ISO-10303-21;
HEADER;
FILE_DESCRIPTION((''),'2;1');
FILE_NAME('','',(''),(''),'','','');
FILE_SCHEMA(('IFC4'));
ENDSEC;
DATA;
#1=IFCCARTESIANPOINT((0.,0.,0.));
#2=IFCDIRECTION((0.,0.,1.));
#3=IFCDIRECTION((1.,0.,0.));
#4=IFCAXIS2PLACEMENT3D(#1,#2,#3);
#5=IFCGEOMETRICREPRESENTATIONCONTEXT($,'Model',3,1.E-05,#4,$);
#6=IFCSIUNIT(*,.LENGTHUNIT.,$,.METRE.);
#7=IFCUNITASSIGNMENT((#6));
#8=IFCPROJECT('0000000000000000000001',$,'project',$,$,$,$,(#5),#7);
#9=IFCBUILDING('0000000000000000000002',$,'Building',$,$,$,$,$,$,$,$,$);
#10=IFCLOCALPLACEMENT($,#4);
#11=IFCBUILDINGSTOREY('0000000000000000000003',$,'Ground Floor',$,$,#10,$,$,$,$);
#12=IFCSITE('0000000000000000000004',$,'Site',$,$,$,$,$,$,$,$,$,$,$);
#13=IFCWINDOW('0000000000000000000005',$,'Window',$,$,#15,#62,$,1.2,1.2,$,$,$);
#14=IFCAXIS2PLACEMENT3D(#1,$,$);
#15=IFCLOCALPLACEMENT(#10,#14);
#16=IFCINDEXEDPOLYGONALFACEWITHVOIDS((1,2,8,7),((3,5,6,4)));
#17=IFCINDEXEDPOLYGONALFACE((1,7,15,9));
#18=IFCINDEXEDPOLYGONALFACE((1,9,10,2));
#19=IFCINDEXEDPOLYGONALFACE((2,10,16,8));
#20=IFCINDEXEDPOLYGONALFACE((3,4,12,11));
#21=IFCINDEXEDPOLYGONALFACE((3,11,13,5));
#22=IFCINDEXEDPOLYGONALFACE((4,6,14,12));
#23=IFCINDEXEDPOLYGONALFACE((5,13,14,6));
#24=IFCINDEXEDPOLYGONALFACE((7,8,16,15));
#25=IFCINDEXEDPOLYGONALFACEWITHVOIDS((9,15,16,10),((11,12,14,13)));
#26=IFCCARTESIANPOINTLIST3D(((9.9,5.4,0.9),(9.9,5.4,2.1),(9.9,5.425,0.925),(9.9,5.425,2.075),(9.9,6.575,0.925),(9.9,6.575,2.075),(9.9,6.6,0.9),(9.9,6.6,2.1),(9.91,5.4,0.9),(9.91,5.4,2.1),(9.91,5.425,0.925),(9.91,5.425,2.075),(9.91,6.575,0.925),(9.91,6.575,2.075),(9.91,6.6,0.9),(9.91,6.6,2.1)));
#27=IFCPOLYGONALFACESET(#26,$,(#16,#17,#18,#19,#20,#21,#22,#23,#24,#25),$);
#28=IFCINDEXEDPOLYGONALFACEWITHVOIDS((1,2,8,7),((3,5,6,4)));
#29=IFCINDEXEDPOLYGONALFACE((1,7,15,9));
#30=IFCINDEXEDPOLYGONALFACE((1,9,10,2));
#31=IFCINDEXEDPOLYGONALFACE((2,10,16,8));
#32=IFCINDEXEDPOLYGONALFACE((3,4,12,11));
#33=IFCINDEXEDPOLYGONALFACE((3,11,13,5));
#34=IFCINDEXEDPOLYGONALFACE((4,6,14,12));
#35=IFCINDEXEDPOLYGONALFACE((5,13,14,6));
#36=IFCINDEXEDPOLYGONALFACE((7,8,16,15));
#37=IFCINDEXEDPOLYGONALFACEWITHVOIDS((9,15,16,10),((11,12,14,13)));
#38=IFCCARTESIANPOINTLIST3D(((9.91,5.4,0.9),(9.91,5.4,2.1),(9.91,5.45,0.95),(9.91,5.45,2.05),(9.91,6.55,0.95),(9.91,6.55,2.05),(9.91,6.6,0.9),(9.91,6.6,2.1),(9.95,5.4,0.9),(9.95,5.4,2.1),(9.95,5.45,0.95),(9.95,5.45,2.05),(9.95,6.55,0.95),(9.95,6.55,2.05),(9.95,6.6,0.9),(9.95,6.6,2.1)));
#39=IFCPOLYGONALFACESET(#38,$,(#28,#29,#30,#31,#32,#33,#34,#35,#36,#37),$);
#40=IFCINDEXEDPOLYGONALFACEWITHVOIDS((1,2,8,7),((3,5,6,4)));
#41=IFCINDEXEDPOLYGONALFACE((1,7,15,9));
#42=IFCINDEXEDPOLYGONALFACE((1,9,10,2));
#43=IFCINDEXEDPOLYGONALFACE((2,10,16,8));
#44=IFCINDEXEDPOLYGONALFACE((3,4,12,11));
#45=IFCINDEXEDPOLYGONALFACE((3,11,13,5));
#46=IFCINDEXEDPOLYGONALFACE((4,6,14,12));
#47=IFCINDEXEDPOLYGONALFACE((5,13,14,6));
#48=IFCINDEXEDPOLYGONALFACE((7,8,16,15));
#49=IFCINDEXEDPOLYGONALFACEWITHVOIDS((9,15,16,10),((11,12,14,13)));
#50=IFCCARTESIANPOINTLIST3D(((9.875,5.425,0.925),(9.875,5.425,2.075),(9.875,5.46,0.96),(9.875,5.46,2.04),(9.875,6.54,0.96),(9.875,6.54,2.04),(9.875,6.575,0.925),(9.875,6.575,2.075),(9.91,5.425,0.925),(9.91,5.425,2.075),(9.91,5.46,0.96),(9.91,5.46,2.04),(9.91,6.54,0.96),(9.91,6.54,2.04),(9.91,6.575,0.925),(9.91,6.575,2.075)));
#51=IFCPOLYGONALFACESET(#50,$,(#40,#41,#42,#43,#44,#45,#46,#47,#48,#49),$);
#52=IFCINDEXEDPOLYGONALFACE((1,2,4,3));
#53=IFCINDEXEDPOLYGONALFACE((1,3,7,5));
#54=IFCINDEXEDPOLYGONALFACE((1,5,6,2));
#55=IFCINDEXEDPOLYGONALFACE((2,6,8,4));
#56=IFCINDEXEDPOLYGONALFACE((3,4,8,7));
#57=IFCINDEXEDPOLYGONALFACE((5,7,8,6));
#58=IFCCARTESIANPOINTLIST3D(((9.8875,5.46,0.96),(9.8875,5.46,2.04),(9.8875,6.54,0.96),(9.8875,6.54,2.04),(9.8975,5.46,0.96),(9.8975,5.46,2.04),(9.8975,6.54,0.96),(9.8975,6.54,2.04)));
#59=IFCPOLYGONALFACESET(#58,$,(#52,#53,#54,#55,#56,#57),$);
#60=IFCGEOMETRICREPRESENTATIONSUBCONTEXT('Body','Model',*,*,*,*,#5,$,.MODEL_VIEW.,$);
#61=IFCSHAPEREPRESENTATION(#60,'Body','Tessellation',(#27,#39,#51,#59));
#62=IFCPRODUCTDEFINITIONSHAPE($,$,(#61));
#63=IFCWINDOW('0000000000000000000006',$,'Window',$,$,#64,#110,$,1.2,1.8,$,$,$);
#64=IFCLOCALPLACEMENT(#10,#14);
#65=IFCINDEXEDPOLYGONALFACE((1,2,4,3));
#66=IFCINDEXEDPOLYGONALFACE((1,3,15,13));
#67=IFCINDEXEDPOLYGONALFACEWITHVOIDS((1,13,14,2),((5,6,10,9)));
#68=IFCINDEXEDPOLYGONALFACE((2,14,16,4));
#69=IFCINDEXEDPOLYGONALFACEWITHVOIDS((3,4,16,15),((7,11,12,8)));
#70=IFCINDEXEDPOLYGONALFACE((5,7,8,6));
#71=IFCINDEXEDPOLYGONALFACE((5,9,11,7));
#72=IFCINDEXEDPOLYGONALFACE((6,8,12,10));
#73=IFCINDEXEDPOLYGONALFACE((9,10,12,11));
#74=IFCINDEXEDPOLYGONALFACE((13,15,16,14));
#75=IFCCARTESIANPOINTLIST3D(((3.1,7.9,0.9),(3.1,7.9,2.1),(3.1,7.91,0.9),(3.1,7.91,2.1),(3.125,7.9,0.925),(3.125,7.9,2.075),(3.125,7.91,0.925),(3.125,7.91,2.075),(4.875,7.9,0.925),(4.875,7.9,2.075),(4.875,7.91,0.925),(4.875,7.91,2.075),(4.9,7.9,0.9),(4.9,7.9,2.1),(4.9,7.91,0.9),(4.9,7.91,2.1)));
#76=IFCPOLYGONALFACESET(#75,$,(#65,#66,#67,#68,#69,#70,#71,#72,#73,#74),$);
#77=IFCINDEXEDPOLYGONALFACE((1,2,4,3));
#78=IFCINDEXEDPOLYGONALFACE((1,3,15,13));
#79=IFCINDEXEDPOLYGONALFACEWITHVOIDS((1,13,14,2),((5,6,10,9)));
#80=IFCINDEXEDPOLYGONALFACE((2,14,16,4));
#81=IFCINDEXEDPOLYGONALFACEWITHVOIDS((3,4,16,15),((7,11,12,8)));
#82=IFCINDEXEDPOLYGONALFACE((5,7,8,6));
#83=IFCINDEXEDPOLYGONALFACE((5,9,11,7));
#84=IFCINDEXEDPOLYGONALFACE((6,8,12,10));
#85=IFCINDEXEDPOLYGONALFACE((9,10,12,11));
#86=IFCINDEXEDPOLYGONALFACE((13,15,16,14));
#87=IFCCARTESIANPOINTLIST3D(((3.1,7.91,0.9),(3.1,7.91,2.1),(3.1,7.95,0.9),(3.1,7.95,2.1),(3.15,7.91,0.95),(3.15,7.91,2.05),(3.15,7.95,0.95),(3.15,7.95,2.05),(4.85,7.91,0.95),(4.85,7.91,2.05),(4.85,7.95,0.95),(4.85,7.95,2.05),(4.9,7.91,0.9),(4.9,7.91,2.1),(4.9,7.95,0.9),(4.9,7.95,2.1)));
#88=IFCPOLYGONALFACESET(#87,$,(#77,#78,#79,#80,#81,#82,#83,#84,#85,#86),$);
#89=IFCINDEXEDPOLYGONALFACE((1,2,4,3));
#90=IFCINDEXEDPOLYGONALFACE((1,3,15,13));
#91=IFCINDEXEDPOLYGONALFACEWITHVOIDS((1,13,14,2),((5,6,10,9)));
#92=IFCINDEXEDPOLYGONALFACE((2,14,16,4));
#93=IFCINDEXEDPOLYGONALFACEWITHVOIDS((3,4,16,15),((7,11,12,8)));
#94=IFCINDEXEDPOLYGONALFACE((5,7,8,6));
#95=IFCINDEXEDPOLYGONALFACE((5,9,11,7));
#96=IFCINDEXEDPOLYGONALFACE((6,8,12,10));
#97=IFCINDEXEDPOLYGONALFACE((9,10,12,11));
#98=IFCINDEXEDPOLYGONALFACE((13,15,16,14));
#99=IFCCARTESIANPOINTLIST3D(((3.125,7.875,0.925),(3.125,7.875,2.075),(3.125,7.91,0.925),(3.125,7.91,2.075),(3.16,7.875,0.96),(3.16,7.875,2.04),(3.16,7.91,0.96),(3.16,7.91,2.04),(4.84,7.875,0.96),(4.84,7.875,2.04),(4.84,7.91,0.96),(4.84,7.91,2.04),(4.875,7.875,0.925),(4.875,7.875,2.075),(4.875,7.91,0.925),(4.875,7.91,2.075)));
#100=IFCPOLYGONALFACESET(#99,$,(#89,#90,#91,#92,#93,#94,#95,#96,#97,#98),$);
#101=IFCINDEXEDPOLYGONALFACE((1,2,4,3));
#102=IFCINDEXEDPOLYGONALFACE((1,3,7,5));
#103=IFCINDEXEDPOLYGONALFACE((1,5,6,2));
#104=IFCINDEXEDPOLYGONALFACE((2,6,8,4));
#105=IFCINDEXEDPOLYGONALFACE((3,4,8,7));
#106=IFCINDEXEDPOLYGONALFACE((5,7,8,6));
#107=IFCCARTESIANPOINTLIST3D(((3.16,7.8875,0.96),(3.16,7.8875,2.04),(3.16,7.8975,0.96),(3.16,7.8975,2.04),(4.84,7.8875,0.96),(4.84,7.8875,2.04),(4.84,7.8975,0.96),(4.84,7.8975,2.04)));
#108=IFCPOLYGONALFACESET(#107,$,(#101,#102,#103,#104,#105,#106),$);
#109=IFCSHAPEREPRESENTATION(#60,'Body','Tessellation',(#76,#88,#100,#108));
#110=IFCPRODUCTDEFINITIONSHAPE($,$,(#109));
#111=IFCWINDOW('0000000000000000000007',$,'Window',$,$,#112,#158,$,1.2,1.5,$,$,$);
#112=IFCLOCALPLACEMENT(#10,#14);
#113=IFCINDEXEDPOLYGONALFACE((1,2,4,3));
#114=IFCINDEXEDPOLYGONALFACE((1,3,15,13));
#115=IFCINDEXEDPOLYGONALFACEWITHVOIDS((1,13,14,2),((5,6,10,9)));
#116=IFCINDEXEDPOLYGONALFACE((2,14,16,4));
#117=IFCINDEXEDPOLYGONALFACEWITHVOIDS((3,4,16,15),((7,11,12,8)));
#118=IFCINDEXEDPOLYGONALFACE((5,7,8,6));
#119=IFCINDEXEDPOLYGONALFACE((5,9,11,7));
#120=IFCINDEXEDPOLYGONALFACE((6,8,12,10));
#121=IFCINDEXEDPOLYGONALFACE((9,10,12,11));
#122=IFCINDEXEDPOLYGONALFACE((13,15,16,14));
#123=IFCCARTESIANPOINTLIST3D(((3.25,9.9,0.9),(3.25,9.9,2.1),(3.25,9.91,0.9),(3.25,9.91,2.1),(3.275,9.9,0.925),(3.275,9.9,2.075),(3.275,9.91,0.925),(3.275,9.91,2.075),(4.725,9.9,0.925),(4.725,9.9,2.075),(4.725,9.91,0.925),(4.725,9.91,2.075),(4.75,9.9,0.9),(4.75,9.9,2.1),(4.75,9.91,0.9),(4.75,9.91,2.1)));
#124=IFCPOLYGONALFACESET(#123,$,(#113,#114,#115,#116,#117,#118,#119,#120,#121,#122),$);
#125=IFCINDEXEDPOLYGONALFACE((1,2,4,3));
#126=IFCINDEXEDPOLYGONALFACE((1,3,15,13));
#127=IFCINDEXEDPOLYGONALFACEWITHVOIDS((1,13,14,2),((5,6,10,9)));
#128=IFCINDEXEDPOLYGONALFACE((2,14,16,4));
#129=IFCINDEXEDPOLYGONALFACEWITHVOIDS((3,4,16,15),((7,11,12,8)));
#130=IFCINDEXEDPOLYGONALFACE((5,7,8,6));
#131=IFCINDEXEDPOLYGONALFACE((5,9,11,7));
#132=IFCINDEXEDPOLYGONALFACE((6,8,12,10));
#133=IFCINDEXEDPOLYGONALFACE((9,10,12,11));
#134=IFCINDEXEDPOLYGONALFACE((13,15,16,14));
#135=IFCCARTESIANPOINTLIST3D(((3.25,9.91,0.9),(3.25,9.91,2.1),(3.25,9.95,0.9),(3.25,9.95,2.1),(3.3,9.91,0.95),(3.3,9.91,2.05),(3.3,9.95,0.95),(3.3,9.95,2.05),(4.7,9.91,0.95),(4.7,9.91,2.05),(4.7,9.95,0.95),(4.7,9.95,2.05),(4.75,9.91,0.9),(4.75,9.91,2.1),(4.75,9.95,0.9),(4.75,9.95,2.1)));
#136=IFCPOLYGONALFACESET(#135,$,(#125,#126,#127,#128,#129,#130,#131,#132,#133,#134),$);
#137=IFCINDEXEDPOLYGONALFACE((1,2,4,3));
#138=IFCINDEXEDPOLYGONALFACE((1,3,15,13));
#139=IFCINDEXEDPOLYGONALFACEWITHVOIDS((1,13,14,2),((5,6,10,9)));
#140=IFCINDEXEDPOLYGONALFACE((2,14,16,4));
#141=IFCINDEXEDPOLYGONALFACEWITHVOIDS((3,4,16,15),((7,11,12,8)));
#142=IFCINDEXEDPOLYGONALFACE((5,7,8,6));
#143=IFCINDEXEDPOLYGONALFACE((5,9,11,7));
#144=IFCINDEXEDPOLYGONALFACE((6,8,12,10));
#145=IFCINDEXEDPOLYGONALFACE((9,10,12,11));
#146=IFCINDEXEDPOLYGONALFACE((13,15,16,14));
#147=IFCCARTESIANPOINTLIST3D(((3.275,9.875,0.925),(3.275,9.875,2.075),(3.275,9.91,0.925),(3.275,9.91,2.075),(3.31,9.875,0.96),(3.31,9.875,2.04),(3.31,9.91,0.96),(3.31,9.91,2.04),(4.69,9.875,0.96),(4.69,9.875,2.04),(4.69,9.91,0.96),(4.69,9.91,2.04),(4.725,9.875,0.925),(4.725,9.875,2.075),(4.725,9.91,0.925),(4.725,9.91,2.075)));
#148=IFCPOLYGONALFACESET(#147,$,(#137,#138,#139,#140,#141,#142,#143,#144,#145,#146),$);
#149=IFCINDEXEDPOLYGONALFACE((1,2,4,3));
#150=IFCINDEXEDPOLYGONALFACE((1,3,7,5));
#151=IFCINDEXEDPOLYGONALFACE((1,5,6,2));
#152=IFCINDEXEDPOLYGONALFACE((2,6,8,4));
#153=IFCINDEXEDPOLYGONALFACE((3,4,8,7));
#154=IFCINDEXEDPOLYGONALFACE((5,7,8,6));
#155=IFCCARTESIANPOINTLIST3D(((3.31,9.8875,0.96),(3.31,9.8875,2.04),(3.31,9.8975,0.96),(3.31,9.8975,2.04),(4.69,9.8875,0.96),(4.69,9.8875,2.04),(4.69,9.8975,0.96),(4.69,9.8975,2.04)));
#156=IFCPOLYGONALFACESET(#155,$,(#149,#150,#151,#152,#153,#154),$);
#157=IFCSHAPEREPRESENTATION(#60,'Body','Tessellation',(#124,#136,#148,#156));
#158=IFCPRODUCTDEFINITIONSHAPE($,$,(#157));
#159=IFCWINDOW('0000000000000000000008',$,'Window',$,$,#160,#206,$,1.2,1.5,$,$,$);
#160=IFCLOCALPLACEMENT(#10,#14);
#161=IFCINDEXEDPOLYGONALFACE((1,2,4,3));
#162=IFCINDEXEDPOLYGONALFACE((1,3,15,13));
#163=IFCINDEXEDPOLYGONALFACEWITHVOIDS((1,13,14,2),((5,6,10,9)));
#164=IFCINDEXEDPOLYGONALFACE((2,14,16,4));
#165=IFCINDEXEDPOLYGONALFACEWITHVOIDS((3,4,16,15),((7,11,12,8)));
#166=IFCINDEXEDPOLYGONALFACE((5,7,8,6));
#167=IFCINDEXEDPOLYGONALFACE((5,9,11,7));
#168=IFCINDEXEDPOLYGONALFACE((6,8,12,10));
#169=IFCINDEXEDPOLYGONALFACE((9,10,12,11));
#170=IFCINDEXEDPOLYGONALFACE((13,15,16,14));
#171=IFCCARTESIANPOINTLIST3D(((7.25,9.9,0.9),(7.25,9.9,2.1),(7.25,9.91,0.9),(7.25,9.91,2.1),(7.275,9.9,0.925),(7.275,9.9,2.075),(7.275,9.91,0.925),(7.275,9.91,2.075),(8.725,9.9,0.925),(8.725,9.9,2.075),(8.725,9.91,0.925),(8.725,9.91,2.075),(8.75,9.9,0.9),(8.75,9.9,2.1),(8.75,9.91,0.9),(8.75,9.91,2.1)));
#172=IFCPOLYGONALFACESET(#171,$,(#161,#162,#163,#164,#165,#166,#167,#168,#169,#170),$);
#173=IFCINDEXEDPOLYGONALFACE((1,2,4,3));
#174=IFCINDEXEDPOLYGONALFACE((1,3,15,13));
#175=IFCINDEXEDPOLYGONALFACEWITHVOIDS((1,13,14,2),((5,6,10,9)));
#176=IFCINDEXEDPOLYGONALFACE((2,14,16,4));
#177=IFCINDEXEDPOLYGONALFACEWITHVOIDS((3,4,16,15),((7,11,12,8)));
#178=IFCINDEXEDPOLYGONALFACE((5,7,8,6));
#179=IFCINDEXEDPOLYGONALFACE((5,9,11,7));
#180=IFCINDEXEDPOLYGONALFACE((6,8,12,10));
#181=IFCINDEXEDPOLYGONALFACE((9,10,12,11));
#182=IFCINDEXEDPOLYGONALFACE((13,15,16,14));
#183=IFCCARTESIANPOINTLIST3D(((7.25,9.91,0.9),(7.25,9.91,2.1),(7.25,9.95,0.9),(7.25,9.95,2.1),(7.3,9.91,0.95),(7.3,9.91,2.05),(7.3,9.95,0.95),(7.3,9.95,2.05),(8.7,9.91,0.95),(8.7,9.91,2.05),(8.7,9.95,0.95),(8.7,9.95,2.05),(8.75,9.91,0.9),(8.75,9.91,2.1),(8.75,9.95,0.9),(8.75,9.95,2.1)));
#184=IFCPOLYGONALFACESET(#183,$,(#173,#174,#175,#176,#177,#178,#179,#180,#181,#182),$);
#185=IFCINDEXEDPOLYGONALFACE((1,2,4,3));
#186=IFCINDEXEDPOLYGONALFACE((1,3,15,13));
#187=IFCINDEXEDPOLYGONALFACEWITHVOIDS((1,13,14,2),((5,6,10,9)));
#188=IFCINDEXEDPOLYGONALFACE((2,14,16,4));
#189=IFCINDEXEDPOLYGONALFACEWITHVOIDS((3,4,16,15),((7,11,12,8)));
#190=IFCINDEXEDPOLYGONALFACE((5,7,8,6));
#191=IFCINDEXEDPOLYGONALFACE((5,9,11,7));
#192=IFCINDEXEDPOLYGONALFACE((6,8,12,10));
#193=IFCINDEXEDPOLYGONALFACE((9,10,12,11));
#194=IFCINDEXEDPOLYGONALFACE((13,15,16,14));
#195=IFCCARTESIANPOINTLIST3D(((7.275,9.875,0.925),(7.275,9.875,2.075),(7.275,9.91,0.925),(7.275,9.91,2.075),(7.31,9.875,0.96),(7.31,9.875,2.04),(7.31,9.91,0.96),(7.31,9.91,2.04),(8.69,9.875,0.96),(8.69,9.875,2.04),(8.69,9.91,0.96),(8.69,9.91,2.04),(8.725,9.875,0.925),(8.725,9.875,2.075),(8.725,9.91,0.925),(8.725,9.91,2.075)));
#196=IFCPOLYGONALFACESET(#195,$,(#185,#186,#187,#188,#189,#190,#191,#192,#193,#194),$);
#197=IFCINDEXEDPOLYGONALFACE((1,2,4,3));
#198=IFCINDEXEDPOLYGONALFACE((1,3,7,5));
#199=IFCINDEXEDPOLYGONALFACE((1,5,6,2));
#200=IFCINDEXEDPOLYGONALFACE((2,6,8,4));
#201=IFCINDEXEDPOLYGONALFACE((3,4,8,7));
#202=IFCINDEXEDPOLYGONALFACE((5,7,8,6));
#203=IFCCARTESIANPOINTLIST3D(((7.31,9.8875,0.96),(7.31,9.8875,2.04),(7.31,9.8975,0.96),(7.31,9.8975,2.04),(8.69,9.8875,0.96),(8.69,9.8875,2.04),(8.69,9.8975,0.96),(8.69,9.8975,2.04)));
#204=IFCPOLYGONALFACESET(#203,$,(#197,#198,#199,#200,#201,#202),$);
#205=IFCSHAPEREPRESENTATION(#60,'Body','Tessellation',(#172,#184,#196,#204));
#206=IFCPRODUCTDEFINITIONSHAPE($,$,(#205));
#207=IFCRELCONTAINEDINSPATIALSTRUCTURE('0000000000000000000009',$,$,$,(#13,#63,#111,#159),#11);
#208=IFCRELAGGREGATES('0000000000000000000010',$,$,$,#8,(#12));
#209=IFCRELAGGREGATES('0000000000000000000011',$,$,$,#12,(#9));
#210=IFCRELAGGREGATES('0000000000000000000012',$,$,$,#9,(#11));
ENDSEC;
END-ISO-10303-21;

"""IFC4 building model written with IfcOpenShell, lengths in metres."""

from ifc_helpers import new_model, si_unit, frame, origin_with_axes, place, context, subcontext, project, spatial, line, indexed_curve, outline, extrude, element, save


model = new_model("IFC4")

# Units and contexts
model_context = context("Model", 3, precision=1e-05, world=origin_with_axes())
body_context = subcontext(model_context, "Body", "Model", "MODEL_VIEW")
ifc_project = project(units=[si_unit("LENGTHUNIT", "METRE")], contexts=[model_context])

# Site, building, storey
site = spatial("IfcSite", under=ifc_project, Name="Site")
building = spatial("IfcBuilding", under=site, Name="Building")
storey_placement = place(None, origin_with_axes())
storey = spatial("IfcBuildingStorey", under=building, at=storey_placement, Name="Ground Floor")

# Windows
window_1_placement = place(storey_placement, frame((10.0, 5.4, 0.9), z_axis=(0.0, 0.0, 1.0), x_axis=(0.0, 1.0, 0.0)))
element("IfcWindow", 1, at=window_1_placement, inside=storey, Name="Window", OverallHeight=1.2, OverallWidth=1.2, context=body_context, shape_type="SweptSolid", body=[
    extrude(outline(indexed_curve([(0.0, 0.0), (1.2, 0.0), (1.2, 1.2), (0.0, 1.2)], segments=[line(1, 2, 3, 4, 1)]), holes=[indexed_curve([(0.025, 0.025), (1.175, 0.025), (1.175, 1.175), (0.025, 1.175)], segments=[line(1, 2, 3, 4, 1)])]), frame((0.0, 0.09, 0.0), z_axis=(0.0, -1.0, 0.0), x_axis=(1.0, 0.0, 0.0)), (0.0, 0.0, -1.0), 0.01),
    extrude(outline(indexed_curve([(0.0, 0.0), (1.2, 0.0), (1.2, 1.2), (0.0, 1.2)], segments=[line(1, 2, 3, 4, 1)]), holes=[indexed_curve([(0.05, 0.05), (1.15, 0.05), (1.15, 1.15), (0.05, 1.15)], segments=[line(1, 2, 3, 4, 1)])]), frame((0.0, 0.05, 0.0), z_axis=(0.0, -1.0, 0.0), x_axis=(1.0, 0.0, 0.0)), (0.0, 0.0, -1.0), 0.04),
    extrude(outline(indexed_curve([(0.0, 0.0), (1.15, 0.0), (1.15, 1.15), (0.0, 1.15)], segments=[line(1, 2, 3, 4, 1)]), holes=[indexed_curve([(0.035, 0.035), (1.115, 0.035), (1.115, 1.115), (0.035, 1.115)], segments=[line(1, 2, 3, 4, 1)])]), frame((0.025, 0.09, 0.025), z_axis=(0.0, -1.0, 0.0), x_axis=(1.0, 0.0, 0.0)), (0.0, 0.0, -1.0), 0.035),
    extrude(outline(indexed_curve([(0.035, 0.035), (1.115, 0.035), (1.115, 1.115), (0.035, 1.115)], segments=[line(1, 2, 3, 4, 1)])), frame((0.025, 0.1025, 0.025), z_axis=(0.0, -1.0, 0.0), x_axis=(1.0, 0.0, 0.0)), (0.0, 0.0, -1.0), 0.01),
])
window_2_placement = place(storey_placement, frame((4.9, 8.0, 0.9), z_axis=(0.0, 0.0, 1.0), x_axis=(-1.0, 0.0, 0.0)))
element("IfcWindow", 2, at=window_2_placement, inside=storey, Name="Window", OverallHeight=1.2, OverallWidth=1.8, context=body_context, shape_type="SweptSolid", body=[
    extrude(outline(indexed_curve([(0.0, 0.0), (1.8, 0.0), (1.8, 1.2), (0.0, 1.2)], segments=[line(1, 2, 3, 4, 1)]), holes=[indexed_curve([(0.025, 0.025), (1.775, 0.025), (1.775, 1.175), (0.025, 1.175)], segments=[line(1, 2, 3, 4, 1)])]), frame((0.0, 0.09, 0.0), z_axis=(0.0, -1.0, 0.0), x_axis=(1.0, 0.0, 0.0)), (0.0, 0.0, -1.0), 0.01),
    extrude(outline(indexed_curve([(0.0, 0.0), (1.8, 0.0), (1.8, 1.2), (0.0, 1.2)], segments=[line(1, 2, 3, 4, 1)]), holes=[indexed_curve([(0.05, 0.05), (1.75, 0.05), (1.75, 1.15), (0.05, 1.15)], segments=[line(1, 2, 3, 4, 1)])]), frame((0.0, 0.05, 0.0), z_axis=(0.0, -1.0, 0.0), x_axis=(1.0, 0.0, 0.0)), (0.0, 0.0, -1.0), 0.04),
    extrude(outline(indexed_curve([(0.0, 0.0), (1.75, 0.0), (1.75, 1.15), (0.0, 1.15)], segments=[line(1, 2, 3, 4, 1)]), holes=[indexed_curve([(0.035, 0.035), (1.715, 0.035), (1.715, 1.115), (0.035, 1.115)], segments=[line(1, 2, 3, 4, 1)])]), frame((0.025, 0.09, 0.025), z_axis=(0.0, -1.0, 0.0), x_axis=(1.0, 0.0, 0.0)), (0.0, 0.0, -1.0), 0.035),
    extrude(outline(indexed_curve([(0.035, 0.035), (1.715, 0.035), (1.715, 1.115), (0.035, 1.115)], segments=[line(1, 2, 3, 4, 1)])), frame((0.025, 0.1025, 0.025), z_axis=(0.0, -1.0, 0.0), x_axis=(1.0, 0.0, 0.0)), (0.0, 0.0, -1.0), 0.01),
])
for number, where, z_axis, x_axis, name in (
    (3, (4.75, 10.0, 0.9), (0.0, 0.0, 1.0), (-1.0, 0.0, 0.0), "Window"),
    (4, (8.75, 10.0, 0.9), (0.0, 0.0, 1.0), (-1.0, 0.0, 0.0), "Window"),
):
    element("IfcWindow", number, at=place(storey_placement, frame(where, z_axis=z_axis, x_axis=x_axis)), inside=storey, Name=name, OverallHeight=1.2, OverallWidth=1.5, context=body_context, shape_type="SweptSolid", body=[
        extrude(outline(indexed_curve([(0.0, 0.0), (1.5, 0.0), (1.5, 1.2), (0.0, 1.2)], segments=[line(1, 2, 3, 4, 1)]), holes=[indexed_curve([(0.025, 0.025), (1.475, 0.025), (1.475, 1.175), (0.025, 1.175)], segments=[line(1, 2, 3, 4, 1)])]), frame((0.0, 0.09, 0.0), z_axis=(0.0, -1.0, 0.0), x_axis=(1.0, 0.0, 0.0)), (0.0, 0.0, -1.0), 0.01),
        extrude(outline(indexed_curve([(0.0, 0.0), (1.5, 0.0), (1.5, 1.2), (0.0, 1.2)], segments=[line(1, 2, 3, 4, 1)]), holes=[indexed_curve([(0.05, 0.05), (1.45, 0.05), (1.45, 1.15), (0.05, 1.15)], segments=[line(1, 2, 3, 4, 1)])]), frame((0.0, 0.05, 0.0), z_axis=(0.0, -1.0, 0.0), x_axis=(1.0, 0.0, 0.0)), (0.0, 0.0, -1.0), 0.04),
        extrude(outline(indexed_curve([(0.0, 0.0), (1.45, 0.0), (1.45, 1.15), (0.0, 1.15)], segments=[line(1, 2, 3, 4, 1)]), holes=[indexed_curve([(0.035, 0.035), (1.415, 0.035), (1.415, 1.115), (0.035, 1.115)], segments=[line(1, 2, 3, 4, 1)])]), frame((0.025, 0.09, 0.025), z_axis=(0.0, -1.0, 0.0), x_axis=(1.0, 0.0, 0.0)), (0.0, 0.0, -1.0), 0.035),
        extrude(outline(indexed_curve([(0.035, 0.035), (1.415, 0.035), (1.415, 1.115), (0.035, 1.115)], segments=[line(1, 2, 3, 4, 1)])), frame((0.025, 0.1025, 0.025), z_axis=(0.0, -1.0, 0.0), x_axis=(1.0, 0.0, 0.0)), (0.0, 0.0, -1.0), 0.01),
    ])

save(model, "model.ifc")
